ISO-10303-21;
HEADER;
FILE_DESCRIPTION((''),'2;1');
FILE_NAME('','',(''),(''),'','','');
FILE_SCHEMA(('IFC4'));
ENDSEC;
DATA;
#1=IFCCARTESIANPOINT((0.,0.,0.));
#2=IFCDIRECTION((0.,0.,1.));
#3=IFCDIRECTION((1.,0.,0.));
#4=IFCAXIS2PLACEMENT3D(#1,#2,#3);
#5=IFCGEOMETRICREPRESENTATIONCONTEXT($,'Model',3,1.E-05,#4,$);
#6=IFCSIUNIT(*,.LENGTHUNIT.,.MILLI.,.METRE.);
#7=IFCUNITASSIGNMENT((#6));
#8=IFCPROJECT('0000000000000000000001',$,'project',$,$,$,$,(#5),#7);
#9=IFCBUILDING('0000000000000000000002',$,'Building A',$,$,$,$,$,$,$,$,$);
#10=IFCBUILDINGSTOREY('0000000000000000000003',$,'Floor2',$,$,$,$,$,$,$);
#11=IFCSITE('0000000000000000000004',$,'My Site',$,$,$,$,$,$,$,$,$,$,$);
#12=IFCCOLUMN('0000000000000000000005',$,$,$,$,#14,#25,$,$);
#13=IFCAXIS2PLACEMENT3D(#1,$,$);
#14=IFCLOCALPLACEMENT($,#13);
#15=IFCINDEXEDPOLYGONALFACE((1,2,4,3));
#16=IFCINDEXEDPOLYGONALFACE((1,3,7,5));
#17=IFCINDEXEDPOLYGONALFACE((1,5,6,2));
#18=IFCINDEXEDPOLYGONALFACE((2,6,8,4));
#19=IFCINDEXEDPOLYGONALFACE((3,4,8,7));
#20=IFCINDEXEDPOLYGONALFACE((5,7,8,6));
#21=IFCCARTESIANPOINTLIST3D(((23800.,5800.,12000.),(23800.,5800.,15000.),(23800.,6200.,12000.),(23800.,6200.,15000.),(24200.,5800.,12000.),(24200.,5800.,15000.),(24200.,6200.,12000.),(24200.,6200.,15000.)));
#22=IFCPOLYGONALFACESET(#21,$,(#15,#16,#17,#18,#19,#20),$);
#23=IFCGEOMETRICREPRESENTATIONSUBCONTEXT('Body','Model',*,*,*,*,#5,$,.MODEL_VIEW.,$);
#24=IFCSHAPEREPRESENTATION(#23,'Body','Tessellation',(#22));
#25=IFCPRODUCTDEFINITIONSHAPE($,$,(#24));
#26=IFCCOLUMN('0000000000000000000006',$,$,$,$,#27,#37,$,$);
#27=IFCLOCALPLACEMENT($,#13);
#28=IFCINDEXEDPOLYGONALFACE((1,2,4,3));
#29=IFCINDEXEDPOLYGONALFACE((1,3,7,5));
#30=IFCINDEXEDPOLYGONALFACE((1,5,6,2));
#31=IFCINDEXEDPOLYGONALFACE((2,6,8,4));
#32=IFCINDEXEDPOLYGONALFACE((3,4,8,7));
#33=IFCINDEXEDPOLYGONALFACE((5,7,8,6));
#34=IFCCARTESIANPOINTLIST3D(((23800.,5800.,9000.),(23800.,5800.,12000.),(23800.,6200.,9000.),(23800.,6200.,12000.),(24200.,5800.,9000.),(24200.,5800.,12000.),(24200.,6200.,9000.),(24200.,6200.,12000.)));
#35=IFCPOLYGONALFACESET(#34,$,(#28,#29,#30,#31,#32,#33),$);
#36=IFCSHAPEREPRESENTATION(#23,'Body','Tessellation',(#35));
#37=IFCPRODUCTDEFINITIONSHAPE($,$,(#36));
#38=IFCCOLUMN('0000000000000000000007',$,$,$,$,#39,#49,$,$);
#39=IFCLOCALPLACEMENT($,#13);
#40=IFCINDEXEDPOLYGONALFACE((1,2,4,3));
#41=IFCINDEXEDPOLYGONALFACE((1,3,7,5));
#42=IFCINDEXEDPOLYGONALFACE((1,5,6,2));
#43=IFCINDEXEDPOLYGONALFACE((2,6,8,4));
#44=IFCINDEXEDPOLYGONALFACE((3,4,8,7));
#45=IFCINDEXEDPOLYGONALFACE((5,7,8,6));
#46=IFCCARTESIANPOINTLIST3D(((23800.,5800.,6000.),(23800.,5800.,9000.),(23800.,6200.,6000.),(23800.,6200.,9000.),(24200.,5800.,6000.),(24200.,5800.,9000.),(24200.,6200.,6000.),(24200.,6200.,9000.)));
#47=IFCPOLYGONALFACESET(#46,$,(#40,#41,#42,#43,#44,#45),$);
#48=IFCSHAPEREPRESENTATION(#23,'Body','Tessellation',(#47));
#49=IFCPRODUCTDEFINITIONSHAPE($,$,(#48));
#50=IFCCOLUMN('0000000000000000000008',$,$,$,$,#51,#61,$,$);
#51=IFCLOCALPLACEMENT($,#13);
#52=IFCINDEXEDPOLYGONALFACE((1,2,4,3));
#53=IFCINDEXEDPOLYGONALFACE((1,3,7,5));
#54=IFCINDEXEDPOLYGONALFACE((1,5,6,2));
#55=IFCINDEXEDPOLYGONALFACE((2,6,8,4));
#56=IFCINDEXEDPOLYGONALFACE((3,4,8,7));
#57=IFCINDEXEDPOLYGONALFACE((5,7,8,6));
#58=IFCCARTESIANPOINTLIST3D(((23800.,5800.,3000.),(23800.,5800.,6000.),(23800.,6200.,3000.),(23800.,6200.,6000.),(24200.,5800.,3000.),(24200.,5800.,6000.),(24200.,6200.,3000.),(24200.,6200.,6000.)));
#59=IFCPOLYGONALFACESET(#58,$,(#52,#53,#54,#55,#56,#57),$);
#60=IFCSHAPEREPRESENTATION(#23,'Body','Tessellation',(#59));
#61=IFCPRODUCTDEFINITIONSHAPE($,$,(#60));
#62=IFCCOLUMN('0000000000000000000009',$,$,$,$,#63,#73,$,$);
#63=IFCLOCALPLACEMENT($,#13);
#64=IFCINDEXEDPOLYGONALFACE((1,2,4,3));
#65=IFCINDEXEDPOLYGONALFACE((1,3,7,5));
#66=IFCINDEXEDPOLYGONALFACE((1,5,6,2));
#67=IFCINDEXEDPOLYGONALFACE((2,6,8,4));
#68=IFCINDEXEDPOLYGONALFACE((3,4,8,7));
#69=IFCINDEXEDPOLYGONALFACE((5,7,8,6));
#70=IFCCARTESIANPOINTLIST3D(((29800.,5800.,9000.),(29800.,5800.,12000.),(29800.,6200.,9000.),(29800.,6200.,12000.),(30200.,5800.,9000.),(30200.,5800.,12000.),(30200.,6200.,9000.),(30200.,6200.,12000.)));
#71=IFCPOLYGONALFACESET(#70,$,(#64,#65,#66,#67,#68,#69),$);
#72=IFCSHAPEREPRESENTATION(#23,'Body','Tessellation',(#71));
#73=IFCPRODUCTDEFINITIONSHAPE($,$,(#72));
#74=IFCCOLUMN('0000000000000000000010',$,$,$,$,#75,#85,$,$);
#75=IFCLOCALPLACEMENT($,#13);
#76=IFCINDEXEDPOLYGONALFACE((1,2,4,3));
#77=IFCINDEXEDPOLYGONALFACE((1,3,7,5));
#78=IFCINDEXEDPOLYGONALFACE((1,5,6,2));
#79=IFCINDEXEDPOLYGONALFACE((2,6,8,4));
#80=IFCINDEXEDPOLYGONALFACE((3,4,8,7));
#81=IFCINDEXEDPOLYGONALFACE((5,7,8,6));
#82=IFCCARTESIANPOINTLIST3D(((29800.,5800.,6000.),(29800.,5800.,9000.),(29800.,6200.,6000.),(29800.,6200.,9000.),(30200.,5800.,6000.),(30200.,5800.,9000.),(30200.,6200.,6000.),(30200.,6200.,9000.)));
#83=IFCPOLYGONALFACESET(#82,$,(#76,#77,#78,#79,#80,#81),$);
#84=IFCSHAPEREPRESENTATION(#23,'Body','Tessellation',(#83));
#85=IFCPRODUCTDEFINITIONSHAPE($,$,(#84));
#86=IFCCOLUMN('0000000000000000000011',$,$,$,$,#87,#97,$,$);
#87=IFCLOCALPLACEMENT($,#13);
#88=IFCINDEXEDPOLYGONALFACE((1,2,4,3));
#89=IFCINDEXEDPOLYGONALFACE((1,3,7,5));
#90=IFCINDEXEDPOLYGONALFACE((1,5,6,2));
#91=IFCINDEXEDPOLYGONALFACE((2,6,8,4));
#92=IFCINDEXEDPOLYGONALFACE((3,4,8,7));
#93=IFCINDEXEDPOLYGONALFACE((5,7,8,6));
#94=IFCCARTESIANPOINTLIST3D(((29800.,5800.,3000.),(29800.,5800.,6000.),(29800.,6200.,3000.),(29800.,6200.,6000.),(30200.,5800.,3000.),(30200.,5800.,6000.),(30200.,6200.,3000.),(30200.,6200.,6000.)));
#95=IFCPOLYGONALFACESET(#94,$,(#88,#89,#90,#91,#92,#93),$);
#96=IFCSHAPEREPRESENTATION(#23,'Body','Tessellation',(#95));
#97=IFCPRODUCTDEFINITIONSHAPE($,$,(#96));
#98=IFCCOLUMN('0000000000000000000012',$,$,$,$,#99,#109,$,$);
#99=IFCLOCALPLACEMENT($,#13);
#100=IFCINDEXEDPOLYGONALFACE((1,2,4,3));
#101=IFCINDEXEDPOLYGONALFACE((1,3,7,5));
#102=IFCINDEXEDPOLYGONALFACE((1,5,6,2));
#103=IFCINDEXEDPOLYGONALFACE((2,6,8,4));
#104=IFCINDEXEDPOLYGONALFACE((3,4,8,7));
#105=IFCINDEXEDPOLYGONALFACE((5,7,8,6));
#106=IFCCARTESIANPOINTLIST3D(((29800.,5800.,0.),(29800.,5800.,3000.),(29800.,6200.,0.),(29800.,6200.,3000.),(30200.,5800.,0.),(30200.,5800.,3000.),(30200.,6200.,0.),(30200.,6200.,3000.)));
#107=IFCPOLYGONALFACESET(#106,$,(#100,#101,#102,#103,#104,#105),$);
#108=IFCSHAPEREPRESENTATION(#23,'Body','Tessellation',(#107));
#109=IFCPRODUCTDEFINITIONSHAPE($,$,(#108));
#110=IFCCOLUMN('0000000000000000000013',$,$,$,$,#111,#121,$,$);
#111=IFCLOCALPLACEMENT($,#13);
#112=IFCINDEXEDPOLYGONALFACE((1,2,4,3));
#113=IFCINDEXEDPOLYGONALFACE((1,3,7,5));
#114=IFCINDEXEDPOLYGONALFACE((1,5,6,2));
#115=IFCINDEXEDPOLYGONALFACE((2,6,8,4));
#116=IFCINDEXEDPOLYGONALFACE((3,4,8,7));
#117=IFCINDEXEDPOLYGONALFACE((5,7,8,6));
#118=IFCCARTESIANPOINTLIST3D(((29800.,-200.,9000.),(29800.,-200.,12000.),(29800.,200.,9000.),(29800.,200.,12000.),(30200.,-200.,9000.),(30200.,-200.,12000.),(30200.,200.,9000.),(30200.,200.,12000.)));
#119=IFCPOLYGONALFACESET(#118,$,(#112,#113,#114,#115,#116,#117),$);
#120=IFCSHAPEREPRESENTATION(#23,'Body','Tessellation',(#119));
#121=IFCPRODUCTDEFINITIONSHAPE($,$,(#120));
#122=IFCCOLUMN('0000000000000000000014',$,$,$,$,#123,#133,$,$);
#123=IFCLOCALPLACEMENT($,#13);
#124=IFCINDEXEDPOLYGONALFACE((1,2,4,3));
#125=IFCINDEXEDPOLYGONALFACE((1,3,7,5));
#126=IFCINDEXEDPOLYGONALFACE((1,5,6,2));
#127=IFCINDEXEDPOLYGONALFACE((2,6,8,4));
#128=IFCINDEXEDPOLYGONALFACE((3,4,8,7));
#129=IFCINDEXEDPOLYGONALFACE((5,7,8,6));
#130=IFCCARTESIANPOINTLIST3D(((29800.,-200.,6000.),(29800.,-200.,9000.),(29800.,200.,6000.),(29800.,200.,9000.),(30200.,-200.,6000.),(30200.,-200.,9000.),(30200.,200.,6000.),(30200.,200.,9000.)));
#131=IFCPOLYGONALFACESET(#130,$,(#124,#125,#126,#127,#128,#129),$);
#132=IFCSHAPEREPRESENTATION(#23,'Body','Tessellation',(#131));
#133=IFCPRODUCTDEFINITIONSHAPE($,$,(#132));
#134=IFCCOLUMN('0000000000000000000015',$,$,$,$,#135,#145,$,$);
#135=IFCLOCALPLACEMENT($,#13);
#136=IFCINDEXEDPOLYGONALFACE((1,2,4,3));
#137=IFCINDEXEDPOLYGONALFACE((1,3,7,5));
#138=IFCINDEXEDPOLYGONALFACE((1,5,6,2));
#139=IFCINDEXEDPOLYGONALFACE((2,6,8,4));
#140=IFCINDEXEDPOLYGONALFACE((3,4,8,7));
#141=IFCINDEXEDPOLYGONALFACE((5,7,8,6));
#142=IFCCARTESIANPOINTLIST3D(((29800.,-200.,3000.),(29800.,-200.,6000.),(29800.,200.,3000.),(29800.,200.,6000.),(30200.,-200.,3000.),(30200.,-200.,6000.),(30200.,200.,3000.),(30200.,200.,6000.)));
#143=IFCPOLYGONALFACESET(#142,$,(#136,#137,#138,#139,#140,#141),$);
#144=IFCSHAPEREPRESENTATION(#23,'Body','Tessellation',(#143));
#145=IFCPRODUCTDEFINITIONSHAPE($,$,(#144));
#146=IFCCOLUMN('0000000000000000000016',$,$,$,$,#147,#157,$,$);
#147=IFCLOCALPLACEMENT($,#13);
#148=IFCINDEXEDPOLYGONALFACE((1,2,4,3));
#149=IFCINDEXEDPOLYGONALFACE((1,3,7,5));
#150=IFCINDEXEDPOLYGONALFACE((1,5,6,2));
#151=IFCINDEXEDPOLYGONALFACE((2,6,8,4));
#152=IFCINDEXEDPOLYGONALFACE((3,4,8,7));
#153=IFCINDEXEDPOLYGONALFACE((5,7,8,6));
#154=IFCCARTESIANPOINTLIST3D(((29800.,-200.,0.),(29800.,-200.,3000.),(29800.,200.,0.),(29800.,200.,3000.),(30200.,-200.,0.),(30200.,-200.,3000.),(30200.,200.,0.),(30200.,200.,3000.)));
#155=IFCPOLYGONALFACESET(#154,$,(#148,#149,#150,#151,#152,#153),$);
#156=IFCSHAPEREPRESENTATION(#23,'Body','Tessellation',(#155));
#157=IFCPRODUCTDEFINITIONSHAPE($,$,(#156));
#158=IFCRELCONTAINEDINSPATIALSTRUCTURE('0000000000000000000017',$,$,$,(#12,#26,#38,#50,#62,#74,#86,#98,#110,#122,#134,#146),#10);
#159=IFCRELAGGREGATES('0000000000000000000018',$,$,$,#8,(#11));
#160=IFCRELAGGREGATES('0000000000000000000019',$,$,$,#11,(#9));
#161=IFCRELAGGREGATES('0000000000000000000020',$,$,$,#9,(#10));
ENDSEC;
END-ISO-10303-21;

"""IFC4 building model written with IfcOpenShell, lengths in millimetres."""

from ifc_helpers import new_model, si_unit, frame, origin_with_axes, place, context, subcontext, project, spatial, line, indexed_curve, outline, extrude, element, save


model = new_model("IFC4")

# Units and contexts
model_context = context("Model", 3, precision=1e-05, world=origin_with_axes())
body_context = subcontext(model_context, "Body", "Model", "MODEL_VIEW")
ifc_project = project(units=[si_unit("LENGTHUNIT", "METRE", prefix="MILLI")], contexts=[model_context])

# Site, building, storey
site = spatial("IfcSite", under=ifc_project, Name="My Site")
building = spatial("IfcBuilding", under=site, Name="Building A")
storey = spatial("IfcBuildingStorey", under=building, Name="Floor2")

# Columns
for number, where, z_axis, x_axis in (
    (1, (24000.0, 6000.0, 12000.0), (0.0, 0.0, 1.0), (1.0, 0.0, 0.0)),
    (2, (24000.0, 6000.0, 9000.0), (0.0, 0.0, 1.0), (1.0, 0.0, 0.0)),
    (3, (24000.0, 6000.0, 6000.0), (0.0, 0.0, 1.0), (1.0, 0.0, 0.0)),
    (4, (24000.0, 6000.0, 3000.0), (0.0, 0.0, 1.0), (1.0, 0.0, 0.0)),
    (5, (30000.0, 6000.0, 9000.0), (0.0, 0.0, 1.0), (1.0, 0.0, 0.0)),
    (6, (30000.0, 6000.0, 6000.0), (0.0, 0.0, 1.0), (1.0, 0.0, 0.0)),
    (7, (30000.0, 6000.0, 3000.0), (0.0, 0.0, 1.0), (1.0, 0.0, 0.0)),
    (8, (30000.0, 6000.0, 0.0), (0.0, 0.0, 1.0), (1.0, 0.0, 0.0)),
    (9, (30000.0, 0.0, 9000.0), (0.0, 0.0, 1.0), (1.0, 0.0, 0.0)),
    (10, (30000.0, 0.0, 6000.0), (0.0, 0.0, 1.0), (1.0, 0.0, 0.0)),
    (11, (30000.0, 0.0, 3000.0), (0.0, 0.0, 1.0), (1.0, 0.0, 0.0)),
    (12, (30000.0, 0.0, 0.0), (0.0, 0.0, 1.0), (1.0, 0.0, 0.0)),
):
    element("IfcColumn", number, at=place(None, frame(where, z_axis=z_axis, x_axis=x_axis)), inside=storey, context=body_context, shape_type="SweptSolid", body=[
        extrude(outline(indexed_curve([(-200.0, -200.0), (200.0, -200.0), (200.0, 200.0), (-200.0, 200.0)], segments=[line(1, 2, 3, 4, 1)])), origin_with_axes(), (0.0, 0.0, 1.0), 3000.0),
    ])

save(model, "model.ifc")
